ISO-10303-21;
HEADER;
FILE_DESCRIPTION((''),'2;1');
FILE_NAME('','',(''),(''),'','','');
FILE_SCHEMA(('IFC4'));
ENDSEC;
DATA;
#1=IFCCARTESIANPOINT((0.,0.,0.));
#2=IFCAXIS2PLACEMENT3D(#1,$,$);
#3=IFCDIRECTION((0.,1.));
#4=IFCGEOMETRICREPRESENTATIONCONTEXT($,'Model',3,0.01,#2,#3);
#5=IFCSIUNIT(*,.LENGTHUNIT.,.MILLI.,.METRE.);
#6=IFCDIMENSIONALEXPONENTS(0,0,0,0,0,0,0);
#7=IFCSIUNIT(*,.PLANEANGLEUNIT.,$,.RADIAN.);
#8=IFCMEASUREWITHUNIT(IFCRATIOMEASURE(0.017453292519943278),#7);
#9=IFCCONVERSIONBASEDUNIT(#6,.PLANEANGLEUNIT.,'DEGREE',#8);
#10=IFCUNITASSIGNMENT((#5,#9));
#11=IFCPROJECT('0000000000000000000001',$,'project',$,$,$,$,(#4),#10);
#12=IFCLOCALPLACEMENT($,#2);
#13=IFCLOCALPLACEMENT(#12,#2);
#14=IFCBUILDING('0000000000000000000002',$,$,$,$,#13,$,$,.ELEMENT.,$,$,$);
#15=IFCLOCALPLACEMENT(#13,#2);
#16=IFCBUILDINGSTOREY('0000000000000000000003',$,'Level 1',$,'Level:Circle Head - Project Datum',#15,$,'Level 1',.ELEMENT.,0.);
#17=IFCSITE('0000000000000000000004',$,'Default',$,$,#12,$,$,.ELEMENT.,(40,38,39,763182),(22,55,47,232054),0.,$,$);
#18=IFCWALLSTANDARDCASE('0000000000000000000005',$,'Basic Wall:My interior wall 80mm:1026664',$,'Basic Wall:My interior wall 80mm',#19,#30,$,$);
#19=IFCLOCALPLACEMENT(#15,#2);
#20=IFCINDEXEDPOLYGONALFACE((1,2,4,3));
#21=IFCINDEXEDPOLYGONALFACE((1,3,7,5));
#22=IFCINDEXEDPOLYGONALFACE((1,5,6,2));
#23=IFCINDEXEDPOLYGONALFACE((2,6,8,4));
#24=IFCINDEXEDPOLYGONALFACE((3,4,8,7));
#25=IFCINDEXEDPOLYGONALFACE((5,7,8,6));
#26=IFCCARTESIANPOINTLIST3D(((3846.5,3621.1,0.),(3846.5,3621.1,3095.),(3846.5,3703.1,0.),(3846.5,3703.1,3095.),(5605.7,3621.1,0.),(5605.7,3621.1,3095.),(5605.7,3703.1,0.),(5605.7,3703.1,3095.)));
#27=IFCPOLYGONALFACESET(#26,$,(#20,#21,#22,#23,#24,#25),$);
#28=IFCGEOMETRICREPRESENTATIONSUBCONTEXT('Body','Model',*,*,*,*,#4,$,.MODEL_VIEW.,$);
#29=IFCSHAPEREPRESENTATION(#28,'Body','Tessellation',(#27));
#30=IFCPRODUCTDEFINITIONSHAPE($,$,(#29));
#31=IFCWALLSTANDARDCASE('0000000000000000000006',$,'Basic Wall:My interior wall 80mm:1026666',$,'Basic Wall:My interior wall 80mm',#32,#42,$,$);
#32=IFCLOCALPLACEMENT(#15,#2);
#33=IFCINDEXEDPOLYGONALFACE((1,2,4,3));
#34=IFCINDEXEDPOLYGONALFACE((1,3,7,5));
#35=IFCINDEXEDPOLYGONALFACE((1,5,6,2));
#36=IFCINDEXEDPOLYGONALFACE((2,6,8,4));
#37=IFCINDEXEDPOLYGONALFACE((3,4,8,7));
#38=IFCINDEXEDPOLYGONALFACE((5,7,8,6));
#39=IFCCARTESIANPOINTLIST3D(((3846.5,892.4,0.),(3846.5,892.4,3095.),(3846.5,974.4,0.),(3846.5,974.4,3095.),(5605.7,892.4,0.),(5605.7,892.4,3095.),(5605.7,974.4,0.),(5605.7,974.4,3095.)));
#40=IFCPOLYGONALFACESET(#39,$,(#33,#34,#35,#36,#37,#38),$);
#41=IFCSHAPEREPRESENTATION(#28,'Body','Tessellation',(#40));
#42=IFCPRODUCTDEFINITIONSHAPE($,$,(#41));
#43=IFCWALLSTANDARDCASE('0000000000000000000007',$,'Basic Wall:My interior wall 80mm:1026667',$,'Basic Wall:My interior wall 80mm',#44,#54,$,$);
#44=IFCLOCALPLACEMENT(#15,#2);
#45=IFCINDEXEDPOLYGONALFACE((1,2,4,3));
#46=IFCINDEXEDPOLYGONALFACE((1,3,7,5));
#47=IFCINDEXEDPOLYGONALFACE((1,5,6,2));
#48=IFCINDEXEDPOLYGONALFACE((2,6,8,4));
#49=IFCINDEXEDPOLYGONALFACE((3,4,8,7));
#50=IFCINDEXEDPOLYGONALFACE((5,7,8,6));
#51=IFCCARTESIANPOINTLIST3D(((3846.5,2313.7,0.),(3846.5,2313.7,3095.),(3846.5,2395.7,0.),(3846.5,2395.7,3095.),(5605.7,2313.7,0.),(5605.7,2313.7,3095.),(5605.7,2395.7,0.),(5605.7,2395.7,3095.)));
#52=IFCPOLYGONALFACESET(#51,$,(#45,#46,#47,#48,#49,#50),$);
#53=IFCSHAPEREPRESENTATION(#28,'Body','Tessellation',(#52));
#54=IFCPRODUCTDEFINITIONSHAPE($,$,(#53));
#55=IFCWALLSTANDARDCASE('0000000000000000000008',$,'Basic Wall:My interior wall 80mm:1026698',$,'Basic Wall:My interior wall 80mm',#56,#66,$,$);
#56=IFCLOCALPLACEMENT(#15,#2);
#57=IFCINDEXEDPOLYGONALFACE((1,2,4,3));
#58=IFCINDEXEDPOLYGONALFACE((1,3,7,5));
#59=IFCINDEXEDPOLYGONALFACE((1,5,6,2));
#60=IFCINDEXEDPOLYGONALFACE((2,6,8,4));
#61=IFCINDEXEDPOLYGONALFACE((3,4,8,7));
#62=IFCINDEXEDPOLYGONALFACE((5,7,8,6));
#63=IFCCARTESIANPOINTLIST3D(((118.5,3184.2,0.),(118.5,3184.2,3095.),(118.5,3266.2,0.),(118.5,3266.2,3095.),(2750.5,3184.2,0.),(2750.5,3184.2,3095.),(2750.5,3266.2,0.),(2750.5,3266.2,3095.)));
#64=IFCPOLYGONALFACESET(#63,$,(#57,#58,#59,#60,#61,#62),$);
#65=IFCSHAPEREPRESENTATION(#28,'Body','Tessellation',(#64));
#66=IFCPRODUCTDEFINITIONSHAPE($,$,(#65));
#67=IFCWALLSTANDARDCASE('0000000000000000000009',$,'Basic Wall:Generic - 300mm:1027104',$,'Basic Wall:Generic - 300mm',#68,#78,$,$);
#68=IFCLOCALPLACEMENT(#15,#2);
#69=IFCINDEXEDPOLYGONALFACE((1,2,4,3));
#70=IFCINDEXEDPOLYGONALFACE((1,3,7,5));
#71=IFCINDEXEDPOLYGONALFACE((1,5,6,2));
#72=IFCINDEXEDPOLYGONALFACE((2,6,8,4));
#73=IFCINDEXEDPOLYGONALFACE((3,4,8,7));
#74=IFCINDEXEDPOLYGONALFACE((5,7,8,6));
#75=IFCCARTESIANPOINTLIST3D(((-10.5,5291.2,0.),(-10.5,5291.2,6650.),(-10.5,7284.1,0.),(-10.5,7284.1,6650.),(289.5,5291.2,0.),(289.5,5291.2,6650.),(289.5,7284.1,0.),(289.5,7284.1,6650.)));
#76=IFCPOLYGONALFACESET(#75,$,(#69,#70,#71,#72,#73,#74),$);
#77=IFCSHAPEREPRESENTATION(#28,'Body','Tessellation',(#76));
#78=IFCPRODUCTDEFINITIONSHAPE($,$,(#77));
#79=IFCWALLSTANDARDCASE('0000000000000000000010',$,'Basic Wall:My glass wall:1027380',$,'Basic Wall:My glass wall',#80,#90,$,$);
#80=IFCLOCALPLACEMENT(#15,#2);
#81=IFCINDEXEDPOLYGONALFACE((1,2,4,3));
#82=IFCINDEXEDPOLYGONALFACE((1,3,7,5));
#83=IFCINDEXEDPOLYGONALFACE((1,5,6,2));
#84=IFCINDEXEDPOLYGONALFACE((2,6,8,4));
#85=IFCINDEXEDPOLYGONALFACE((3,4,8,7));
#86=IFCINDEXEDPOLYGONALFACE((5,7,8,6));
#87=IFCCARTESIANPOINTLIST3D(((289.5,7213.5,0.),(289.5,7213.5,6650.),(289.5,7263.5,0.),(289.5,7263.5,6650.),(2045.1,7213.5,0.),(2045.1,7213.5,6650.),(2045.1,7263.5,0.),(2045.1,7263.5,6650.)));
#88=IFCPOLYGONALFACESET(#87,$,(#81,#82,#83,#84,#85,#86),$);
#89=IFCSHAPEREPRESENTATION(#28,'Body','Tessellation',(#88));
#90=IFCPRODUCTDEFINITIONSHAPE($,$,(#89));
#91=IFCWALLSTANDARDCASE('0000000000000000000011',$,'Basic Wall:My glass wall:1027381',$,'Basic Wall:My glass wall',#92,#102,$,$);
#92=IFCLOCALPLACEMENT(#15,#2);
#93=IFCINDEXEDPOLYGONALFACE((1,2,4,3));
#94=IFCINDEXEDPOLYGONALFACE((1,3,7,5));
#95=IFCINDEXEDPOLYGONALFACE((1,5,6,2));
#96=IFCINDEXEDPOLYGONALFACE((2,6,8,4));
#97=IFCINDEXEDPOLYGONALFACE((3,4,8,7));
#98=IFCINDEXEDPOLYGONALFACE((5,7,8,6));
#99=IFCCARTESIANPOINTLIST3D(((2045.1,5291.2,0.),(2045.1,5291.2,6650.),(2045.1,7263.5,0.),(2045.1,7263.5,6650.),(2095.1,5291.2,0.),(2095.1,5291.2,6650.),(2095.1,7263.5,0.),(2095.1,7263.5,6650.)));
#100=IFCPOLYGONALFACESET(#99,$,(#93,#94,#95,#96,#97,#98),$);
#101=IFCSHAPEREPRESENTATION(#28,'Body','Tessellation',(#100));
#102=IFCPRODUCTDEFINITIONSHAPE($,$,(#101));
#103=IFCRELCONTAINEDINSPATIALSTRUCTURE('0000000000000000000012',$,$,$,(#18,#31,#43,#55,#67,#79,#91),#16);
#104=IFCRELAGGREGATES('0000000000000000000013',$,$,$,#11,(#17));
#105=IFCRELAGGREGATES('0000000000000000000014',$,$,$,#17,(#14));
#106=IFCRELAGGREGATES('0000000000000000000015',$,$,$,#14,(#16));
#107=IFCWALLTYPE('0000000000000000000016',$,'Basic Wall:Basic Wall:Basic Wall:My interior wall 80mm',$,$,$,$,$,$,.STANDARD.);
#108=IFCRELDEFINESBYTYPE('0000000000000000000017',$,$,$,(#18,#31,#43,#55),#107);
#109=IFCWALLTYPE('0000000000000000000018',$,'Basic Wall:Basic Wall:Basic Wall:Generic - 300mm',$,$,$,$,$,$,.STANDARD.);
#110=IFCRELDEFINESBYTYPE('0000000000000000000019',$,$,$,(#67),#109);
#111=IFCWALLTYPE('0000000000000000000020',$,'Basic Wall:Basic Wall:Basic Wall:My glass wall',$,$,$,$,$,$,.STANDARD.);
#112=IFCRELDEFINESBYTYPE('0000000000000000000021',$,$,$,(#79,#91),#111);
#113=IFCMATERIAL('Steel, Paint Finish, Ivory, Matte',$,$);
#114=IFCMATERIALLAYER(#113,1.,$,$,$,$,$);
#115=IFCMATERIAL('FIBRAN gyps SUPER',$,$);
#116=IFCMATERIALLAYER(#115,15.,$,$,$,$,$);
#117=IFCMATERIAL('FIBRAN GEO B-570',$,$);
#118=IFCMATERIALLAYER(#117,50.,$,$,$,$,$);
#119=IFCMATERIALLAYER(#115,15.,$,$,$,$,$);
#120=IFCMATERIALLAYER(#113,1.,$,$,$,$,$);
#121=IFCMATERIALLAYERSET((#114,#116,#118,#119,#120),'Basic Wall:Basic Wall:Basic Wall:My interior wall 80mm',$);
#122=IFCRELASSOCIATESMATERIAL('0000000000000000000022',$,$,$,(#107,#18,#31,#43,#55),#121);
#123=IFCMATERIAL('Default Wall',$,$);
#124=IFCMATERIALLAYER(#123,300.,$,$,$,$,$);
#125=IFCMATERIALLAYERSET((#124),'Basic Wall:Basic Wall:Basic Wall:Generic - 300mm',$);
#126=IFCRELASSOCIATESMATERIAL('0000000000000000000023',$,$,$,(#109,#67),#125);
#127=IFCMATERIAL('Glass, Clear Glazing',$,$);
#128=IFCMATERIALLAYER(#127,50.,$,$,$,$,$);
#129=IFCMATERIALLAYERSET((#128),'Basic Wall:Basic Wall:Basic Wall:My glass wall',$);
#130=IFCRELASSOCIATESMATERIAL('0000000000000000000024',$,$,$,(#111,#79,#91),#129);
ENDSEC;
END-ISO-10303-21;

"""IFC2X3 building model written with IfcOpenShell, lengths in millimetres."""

from ifc_helpers import new_model, entity, si_unit, converted_unit, direction, frame, frame_2d, origin, place, context, subcontext, project, spatial, rectangle, extrude, material, layer, layer_set, layer_usage, type_object, element, save


model = new_model("IFC2X3")

# Units and contexts
model_context = context("Model", 3, precision=0.01, world=origin(), true_north=direction((0.0, 1.0)))
body_context = subcontext(model_context, "Body", "Model", "MODEL_VIEW")
ifc_project = project(units=[si_unit("LENGTHUNIT", "METRE", prefix="MILLI"), converted_unit("PLANEANGLEUNIT", "DEGREE", entity("IfcRatioMeasure", 0.017453292519943278), si_unit("PLANEANGLEUNIT", "RADIAN"), dimensions=[0, 0, 0, 0, 0, 0, 0])], contexts=[model_context])

# Site, building, storey
site_placement = place(None, origin())
site = spatial("IfcSite", under=ifc_project, at=site_placement, Name="Default", CompositionType="ELEMENT", RefLatitude=(40, 38, 39, 763182), RefLongitude=(22, 55, 47, 232054), RefElevation=0.0)
building_placement = place(site_placement, origin())
building = spatial("IfcBuilding", under=site, at=building_placement, CompositionType="ELEMENT")
storey_placement = place(building_placement, origin())
storey = spatial("IfcBuildingStorey", under=building, at=storey_placement, Name="Level 1", ObjectType="Level:Circle Head - Project Datum", LongName="Level 1", CompositionType="ELEMENT", Elevation=0.0)

# Shared definitions
ifc_material_1 = material(Name="FIBRAN gyps SUPER")

# Shared definitions
ifc_material_2 = material(Name="Steel, Paint Finish, Ivory, Matte")
ifc_layer_1 = layer(ifc_material_2, 1.0)
ifc_layer_2 = layer(ifc_material_1, 15.0)
ifc_material_3 = material(Name="FIBRAN GEO B-570")
ifc_layer_3 = layer(ifc_material_3, 50.0)
ifc_layer_4 = layer(ifc_material_1, 15.0)
ifc_layer_5 = layer(ifc_material_2, 1.0)
ifc_layer_set_1 = layer_set([ifc_layer_1, ifc_layer_2, ifc_layer_3, ifc_layer_4, ifc_layer_5], Name="Basic Wall:Basic Wall:Basic Wall:My interior wall 80mm")
wall_type_1 = type_object("IfcWallType", Name="Basic Wall:Basic Wall:Basic Wall:My interior wall 80mm", PredefinedType="STANDARD", material=ifc_layer_set_1)

# Walls
ifc_layer_usage_1 = layer_usage(ifc_layer_set_1, "AXIS2", "NEGATIVE", 41.0)
wall_1_placement = place(storey_placement, frame((5605.7, 3662.1, 0.0), z_axis=(0.0, 0.0, 1.0), x_axis=(-1.0, 0.0, 0.0)))
element("IfcWallStandardCase", 1, at=wall_1_placement, inside=storey, type_object=wall_type_1, material=ifc_layer_usage_1, Name="Basic Wall:My interior wall 80mm:1026664", ObjectType="Basic Wall:My interior wall 80mm", context=body_context, shape_type="SweptSolid", body=[
    extrude(rectangle(XDim=1759.2, YDim=82.0, at=frame_2d((879.6, 0.0), x_axis=(-1.0, 0.0))), origin(), (0.0, 0.0, 1.0), 3095.0),
])
ifc_layer_usage_2 = layer_usage(ifc_layer_set_1, "AXIS2", "NEGATIVE", 41.0)
wall_2_placement = place(storey_placement, frame((5605.7, 933.4, 0.0), z_axis=(0.0, 0.0, 1.0), x_axis=(-1.0, 0.0, 0.0)))
element("IfcWallStandardCase", 2, at=wall_2_placement, inside=storey, type_object=wall_type_1, material=ifc_layer_usage_2, Name="Basic Wall:My interior wall 80mm:1026666", ObjectType="Basic Wall:My interior wall 80mm", context=body_context, shape_type="SweptSolid", body=[
    extrude(rectangle(XDim=1759.2, YDim=82.0, at=frame_2d((879.6, 0.0), x_axis=(-1.0, 0.0))), origin(), (0.0, 0.0, 1.0), 3095.0),
])
ifc_layer_usage_3 = layer_usage(ifc_layer_set_1, "AXIS2", "NEGATIVE", 41.0)
wall_3_placement = place(storey_placement, frame((5605.7, 2354.7, 0.0), z_axis=(0.0, 0.0, 1.0), x_axis=(-1.0, 0.0, 0.0)))
element("IfcWallStandardCase", 3, at=wall_3_placement, inside=storey, type_object=wall_type_1, material=ifc_layer_usage_3, Name="Basic Wall:My interior wall 80mm:1026667", ObjectType="Basic Wall:My interior wall 80mm", context=body_context, shape_type="SweptSolid", body=[
    extrude(rectangle(XDim=1759.2, YDim=82.0, at=frame_2d((879.6, 0.0), x_axis=(-1.0, 0.0))), origin(), (0.0, 0.0, 1.0), 3095.0),
])
ifc_layer_usage_4 = layer_usage(ifc_layer_set_1, "AXIS2", "NEGATIVE", 41.0)
wall_4_placement = place(storey_placement, frame((2750.5, 3225.2, 0.0), z_axis=(0.0, 0.0, 1.0), x_axis=(-1.0, 0.0, 0.0)))
element("IfcWallStandardCase", 4, at=wall_4_placement, inside=storey, type_object=wall_type_1, material=ifc_layer_usage_4, Name="Basic Wall:My interior wall 80mm:1026698", ObjectType="Basic Wall:My interior wall 80mm", context=body_context, shape_type="SweptSolid", body=[
    extrude(rectangle(XDim=2632.0, YDim=82.0, at=frame_2d((1316.0, 0.0), x_axis=(-1.0, 0.0))), origin(), (0.0, 0.0, 1.0), 3095.0),
])
ifc_material_4 = material(Name="Default Wall")
ifc_layer_6 = layer(ifc_material_4, 300.0)
ifc_layer_set_2 = layer_set([ifc_layer_6], Name="Basic Wall:Basic Wall:Basic Wall:Generic - 300mm")
ifc_layer_usage_5 = layer_usage(ifc_layer_set_2, "AXIS2", "NEGATIVE", 150.0)
wall_type_2 = type_object("IfcWallType", Name="Basic Wall:Basic Wall:Basic Wall:Generic - 300mm", PredefinedType="STANDARD", material=ifc_layer_set_2)
wall_5_placement = place(storey_placement, frame((139.5, 5291.2, 0.0), z_axis=(0.0, 0.0, 1.0), x_axis=(0.0, 1.0, 0.0)))
element("IfcWallStandardCase", 5, at=wall_5_placement, inside=storey, type_object=wall_type_2, material=ifc_layer_usage_5, Name="Basic Wall:Generic - 300mm:1027104", ObjectType="Basic Wall:Generic - 300mm", context=body_context, shape_type="SweptSolid", body=[
    extrude(rectangle(XDim=1992.9, YDim=300.0, at=frame_2d((996.5, 0.0), x_axis=(-1.0, 0.0))), origin(), (0.0, 0.0, 1.0), 6650.0),
])
ifc_material_5 = material(Name="Glass, Clear Glazing")
ifc_layer_7 = layer(ifc_material_5, 50.0)
ifc_layer_set_3 = layer_set([ifc_layer_7], Name="Basic Wall:Basic Wall:Basic Wall:My glass wall")
ifc_layer_usage_6 = layer_usage(ifc_layer_set_3, "AXIS2", "NEGATIVE", 25.0)
wall_type_3 = type_object("IfcWallType", Name="Basic Wall:Basic Wall:Basic Wall:My glass wall", PredefinedType="STANDARD", material=ifc_layer_set_3)
wall_6_placement = place(storey_placement, frame((289.5, 7238.5, 0.0)))
element("IfcWallStandardCase", 6, at=wall_6_placement, inside=storey, type_object=wall_type_3, material=ifc_layer_usage_6, Name="Basic Wall:My glass wall:1027380", ObjectType="Basic Wall:My glass wall", context=body_context, shape_type="SweptSolid", body=[
    extrude(rectangle(XDim=1755.6, YDim=50.0, at=frame_2d((877.8, 0.0), x_axis=(-1.0, 0.0))), origin(), (0.0, 0.0, 1.0), 6650.0),
])
ifc_layer_usage_7 = layer_usage(ifc_layer_set_3, "AXIS2", "NEGATIVE", 25.0)
wall_7_placement = place(storey_placement, frame((2070.1, 7263.5, 0.0), z_axis=(0.0, 0.0, 1.0), x_axis=(0.0, -1.0, 0.0)))
element("IfcWallStandardCase", 7, at=wall_7_placement, inside=storey, type_object=wall_type_3, material=ifc_layer_usage_7, Name="Basic Wall:My glass wall:1027381", ObjectType="Basic Wall:My glass wall", context=body_context, shape_type="SweptSolid", body=[
    extrude(rectangle(XDim=1972.4, YDim=50.0, at=frame_2d((986.2, 0.0), x_axis=(-1.0, 0.0))), origin(), (0.0, 0.0, 1.0), 6650.0),
])

save(model, "model.ifc")
